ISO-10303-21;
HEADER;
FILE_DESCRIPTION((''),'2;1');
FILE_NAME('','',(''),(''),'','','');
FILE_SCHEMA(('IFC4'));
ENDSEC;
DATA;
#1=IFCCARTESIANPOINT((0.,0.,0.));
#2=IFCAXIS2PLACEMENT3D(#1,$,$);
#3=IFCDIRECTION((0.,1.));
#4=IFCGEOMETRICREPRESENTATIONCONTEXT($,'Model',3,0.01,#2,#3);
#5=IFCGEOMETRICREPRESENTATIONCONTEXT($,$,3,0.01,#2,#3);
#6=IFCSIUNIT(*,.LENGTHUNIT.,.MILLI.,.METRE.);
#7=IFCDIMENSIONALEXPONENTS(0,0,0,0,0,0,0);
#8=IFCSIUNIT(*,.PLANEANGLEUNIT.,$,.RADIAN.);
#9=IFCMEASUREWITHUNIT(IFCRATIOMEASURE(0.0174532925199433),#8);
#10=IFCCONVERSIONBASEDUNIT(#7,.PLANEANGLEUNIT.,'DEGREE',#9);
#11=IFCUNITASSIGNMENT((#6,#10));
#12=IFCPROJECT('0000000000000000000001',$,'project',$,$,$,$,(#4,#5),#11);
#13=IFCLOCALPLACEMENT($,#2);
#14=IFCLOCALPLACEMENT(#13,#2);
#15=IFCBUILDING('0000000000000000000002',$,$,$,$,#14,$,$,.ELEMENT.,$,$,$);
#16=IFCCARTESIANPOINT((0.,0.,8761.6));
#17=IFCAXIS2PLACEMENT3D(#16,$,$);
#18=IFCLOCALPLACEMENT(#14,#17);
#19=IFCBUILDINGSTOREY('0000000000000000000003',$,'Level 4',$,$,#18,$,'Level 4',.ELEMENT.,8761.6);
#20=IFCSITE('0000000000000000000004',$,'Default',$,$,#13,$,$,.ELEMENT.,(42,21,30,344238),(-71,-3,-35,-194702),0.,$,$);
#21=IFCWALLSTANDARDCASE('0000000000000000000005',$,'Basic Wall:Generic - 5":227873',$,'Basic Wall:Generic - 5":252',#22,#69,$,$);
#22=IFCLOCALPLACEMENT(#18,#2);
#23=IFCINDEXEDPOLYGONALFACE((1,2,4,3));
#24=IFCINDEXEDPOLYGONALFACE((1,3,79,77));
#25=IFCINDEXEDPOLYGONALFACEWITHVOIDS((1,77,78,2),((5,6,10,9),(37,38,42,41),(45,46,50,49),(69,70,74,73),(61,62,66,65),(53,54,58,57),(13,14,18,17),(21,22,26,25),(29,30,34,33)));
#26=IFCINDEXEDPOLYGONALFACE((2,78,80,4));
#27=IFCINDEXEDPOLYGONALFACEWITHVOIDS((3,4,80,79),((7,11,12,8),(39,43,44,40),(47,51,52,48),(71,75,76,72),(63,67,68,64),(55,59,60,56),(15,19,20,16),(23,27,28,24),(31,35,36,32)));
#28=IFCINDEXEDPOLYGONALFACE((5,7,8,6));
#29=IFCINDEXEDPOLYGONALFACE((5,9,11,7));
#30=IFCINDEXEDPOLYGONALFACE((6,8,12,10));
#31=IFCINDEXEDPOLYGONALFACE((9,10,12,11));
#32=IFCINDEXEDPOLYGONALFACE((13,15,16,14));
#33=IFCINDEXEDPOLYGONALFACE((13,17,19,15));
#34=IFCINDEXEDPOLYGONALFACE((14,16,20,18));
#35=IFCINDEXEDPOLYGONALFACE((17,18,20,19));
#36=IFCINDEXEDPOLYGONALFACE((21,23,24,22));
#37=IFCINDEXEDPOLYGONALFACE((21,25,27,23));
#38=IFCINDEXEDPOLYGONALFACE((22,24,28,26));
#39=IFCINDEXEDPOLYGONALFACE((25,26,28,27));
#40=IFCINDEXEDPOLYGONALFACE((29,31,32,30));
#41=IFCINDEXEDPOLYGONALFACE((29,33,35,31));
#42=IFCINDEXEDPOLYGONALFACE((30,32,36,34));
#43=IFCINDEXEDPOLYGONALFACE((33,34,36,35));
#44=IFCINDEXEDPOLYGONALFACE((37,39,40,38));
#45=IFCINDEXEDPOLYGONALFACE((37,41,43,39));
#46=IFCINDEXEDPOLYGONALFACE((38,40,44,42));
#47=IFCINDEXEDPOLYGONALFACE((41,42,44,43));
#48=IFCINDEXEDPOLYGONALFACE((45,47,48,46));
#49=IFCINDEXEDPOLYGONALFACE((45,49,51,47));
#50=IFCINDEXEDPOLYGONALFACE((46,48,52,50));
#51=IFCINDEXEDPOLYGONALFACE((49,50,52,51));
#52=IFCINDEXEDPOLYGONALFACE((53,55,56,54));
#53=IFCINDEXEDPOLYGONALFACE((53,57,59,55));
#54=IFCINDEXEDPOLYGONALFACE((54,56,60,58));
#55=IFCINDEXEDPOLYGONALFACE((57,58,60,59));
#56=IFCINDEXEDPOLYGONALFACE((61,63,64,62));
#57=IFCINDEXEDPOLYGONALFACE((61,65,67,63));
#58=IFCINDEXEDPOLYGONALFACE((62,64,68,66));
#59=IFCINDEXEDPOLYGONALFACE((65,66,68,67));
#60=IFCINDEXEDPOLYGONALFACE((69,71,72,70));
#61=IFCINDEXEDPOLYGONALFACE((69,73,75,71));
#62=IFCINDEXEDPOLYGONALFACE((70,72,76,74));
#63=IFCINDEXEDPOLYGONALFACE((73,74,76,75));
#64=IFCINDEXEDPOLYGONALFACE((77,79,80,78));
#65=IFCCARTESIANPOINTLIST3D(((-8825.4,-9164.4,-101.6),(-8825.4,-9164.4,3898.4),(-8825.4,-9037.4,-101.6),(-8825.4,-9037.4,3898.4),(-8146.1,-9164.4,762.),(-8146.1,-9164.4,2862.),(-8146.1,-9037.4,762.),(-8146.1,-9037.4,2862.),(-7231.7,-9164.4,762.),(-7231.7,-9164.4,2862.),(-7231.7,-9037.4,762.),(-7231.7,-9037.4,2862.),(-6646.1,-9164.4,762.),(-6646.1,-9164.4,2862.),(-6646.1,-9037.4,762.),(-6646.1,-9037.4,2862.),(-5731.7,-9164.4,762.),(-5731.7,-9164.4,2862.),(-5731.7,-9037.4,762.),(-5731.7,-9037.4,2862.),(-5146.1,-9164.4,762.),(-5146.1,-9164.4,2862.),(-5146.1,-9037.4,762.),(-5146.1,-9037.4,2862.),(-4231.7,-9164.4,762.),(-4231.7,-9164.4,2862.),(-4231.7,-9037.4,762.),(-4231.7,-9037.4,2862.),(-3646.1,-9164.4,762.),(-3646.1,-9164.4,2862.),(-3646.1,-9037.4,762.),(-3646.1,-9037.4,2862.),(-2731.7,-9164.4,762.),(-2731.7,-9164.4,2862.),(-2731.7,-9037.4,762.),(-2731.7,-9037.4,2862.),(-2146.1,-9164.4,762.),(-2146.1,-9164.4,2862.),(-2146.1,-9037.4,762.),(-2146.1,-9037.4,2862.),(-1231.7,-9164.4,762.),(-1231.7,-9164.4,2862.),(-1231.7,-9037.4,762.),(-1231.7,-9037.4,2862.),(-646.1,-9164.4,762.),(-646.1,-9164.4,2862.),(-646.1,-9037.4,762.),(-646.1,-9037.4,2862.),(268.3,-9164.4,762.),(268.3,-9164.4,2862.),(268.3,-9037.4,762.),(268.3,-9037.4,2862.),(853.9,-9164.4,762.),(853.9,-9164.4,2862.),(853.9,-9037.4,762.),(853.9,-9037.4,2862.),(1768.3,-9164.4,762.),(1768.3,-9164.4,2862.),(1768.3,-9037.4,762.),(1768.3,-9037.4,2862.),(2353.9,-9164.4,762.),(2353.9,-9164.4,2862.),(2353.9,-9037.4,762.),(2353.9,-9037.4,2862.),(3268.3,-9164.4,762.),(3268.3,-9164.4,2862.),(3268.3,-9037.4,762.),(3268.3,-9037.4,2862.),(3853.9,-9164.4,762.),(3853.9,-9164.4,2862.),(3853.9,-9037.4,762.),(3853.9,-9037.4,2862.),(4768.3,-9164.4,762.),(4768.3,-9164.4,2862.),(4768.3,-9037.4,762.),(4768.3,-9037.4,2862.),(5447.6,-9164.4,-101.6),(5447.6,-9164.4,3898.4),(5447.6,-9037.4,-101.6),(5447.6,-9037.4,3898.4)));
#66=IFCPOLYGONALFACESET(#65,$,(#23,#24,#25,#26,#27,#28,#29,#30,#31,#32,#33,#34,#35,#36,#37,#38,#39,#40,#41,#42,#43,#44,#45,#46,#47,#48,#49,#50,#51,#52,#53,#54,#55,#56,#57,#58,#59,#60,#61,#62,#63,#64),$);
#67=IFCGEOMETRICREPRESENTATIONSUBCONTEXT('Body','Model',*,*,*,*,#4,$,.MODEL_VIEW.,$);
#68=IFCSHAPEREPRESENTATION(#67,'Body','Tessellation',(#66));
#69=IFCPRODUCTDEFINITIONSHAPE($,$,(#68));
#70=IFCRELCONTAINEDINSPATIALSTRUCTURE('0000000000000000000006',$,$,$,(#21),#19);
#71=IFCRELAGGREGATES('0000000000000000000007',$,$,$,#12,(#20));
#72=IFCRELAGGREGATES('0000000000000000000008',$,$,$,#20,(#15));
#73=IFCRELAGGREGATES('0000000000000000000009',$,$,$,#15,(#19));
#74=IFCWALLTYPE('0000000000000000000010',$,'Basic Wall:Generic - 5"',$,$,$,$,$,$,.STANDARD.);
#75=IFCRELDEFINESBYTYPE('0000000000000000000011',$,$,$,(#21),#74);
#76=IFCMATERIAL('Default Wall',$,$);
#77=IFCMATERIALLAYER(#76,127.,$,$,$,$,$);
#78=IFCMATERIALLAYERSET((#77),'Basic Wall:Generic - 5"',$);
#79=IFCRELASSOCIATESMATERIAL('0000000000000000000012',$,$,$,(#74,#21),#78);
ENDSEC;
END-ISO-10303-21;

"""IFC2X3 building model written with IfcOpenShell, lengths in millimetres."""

from ifc_helpers import new_model, entity, si_unit, converted_unit, direction, frame, frame_2d, origin, place, context, subcontext, project, spatial, polyline, rectangle, extrude, clip, bounded_halfspace, material, layer, layer_set, layer_usage, type_object, element, save


model = new_model("IFC2X3")

# Units and contexts
model_context = context("Model", 3, precision=0.01, world=origin(), true_north=direction((0.0, 1.0)))
context_of_model = context(None, 3, precision=0.01, world=origin(), true_north=direction((0.0, 1.0)))
body_context = subcontext(model_context, "Body", "Model", "MODEL_VIEW")
ifc_project = project(units=[si_unit("LENGTHUNIT", "METRE", prefix="MILLI"), converted_unit("PLANEANGLEUNIT", "DEGREE", entity("IfcRatioMeasure", 0.0174532925199433), si_unit("PLANEANGLEUNIT", "RADIAN"), dimensions=[0, 0, 0, 0, 0, 0, 0])], contexts=[model_context, context_of_model])

# Site, building, storey
site_placement = place(None, origin())
site = spatial("IfcSite", under=ifc_project, at=site_placement, Name="Default", CompositionType="ELEMENT", RefLatitude=(42, 21, 30, 344238), RefLongitude=(-71, -3, -35, -194702), RefElevation=0.0)
building_placement = place(site_placement, origin())
building = spatial("IfcBuilding", under=site, at=building_placement, CompositionType="ELEMENT")
storey_placement = place(building_placement, frame((0.0, 0.0, 8761.6)))
storey = spatial("IfcBuildingStorey", under=building, at=storey_placement, Name="Level 4", LongName="Level 4", CompositionType="ELEMENT", Elevation=8761.6)

# Wall, openings
ifc_material = material(Name="Default Wall")
ifc_layer = layer(ifc_material, 127.0)
ifc_layer_set = layer_set([ifc_layer], Name="Basic Wall:Generic - 5\"")
wall_type = type_object("IfcWallType", Name="Basic Wall:Generic - 5\"", PredefinedType="STANDARD", material=ifc_layer_set)
ifc_layer_usage_1 = layer_usage(ifc_layer_set, "AXIS2", "NEGATIVE", 63.5)
wall_1_placement = place(storey_placement, frame((5447.6, -9100.9, -101.6), z_axis=(0.0, 0.0, 1.0), x_axis=(-1.0, 0.0, 0.0)))
wall_1 = element("IfcWallStandardCase", 1, at=wall_1_placement, inside=storey, type_object=wall_type, material=ifc_layer_usage_1, Name="Basic Wall:Generic - 5\":227873", ObjectType="Basic Wall:Generic - 5\":252", context=body_context, shape_type="Clipping", body=[
    clip(extrude(rectangle(XDim=14273.0, YDim=127.0, at=frame_2d((7136.5, 0.0), x_axis=(-1.0, 0.0))), origin(), (0.0, 0.0, 1.0), 4000.0), bounded_halfspace(frame((0.0, -63.5, 4000.0), z_axis=(0.0, 0.0, -1.0), x_axis=(0.0, 1.0, 0.0)), True, frame((0.0, -63.5, 4000.0)), polyline([(0.0, 0.0), (14273.0, 0.0), (14273.0, 127.0), (0.0, 127.0), (0.0, 0.0)]))),
])
opening_1_placement = place(wall_1_placement, frame((13593.7, 63.5, 863.6)))
element("IfcOpeningElement", 2, at=opening_1_placement, cuts=wall_1, ObjectType="Opening", context=body_context, shape_type="SweptSolid", body=[
    extrude(rectangle(XDim=2100.0, YDim=914.4, at=frame_2d((1050.0, 457.2), x_axis=(-1.0, 0.0))), frame((0.0, 0.0, 0.0), z_axis=(0.0, -1.0, 0.0), x_axis=(0.0, 0.0, 1.0)), (0.0, 0.0, 1.0), 127.0),
])
opening_2_placement = place(wall_1_placement, frame((10593.7, 63.5, 863.6)))
element("IfcOpeningElement", 3, at=opening_2_placement, cuts=wall_1, ObjectType="Opening", context=body_context, shape_type="SweptSolid", body=[
    extrude(rectangle(XDim=2100.0, YDim=914.4, at=frame_2d((1050.0, 457.2), x_axis=(-1.0, 0.0))), frame((0.0, 0.0, 0.0), z_axis=(0.0, -1.0, 0.0), x_axis=(0.0, 0.0, 1.0)), (0.0, 0.0, 1.0), 127.0),
])
opening_3_placement = place(wall_1_placement, frame((7593.7, 63.5, 863.6)))
element("IfcOpeningElement", 4, at=opening_3_placement, cuts=wall_1, ObjectType="Opening", context=body_context, shape_type="SweptSolid", body=[
    extrude(rectangle(XDim=2100.0, YDim=914.4, at=frame_2d((1050.0, 457.2), x_axis=(-1.0, 0.0))), frame((0.0, 0.0, 0.0), z_axis=(0.0, -1.0, 0.0), x_axis=(0.0, 0.0, 1.0)), (0.0, 0.0, 1.0), 127.0),
])
opening_4_placement = place(wall_1_placement, frame((4593.7, 63.5, 863.6)))
element("IfcOpeningElement", 5, at=opening_4_placement, cuts=wall_1, ObjectType="Opening", context=body_context, shape_type="SweptSolid", body=[
    extrude(rectangle(XDim=2100.0, YDim=914.4, at=frame_2d((1050.0, 457.2), x_axis=(-1.0, 0.0))), frame((0.0, 0.0, 0.0), z_axis=(0.0, -1.0, 0.0), x_axis=(0.0, 0.0, 1.0)), (0.0, 0.0, 1.0), 127.0),
])
opening_5_placement = place(wall_1_placement, frame((1593.7, 63.5, 863.6)))
element("IfcOpeningElement", 6, at=opening_5_placement, cuts=wall_1, ObjectType="Opening", context=body_context, shape_type="SweptSolid", body=[
    extrude(rectangle(XDim=2100.0, YDim=914.4, at=frame_2d((1050.0, 457.2), x_axis=(-1.0, 0.0))), frame((0.0, 0.0, 0.0), z_axis=(0.0, -1.0, 0.0), x_axis=(0.0, 0.0, 1.0)), (0.0, 0.0, 1.0), 127.0),
])
opening_6_placement = place(wall_1_placement, frame((12093.7, 63.5, 863.6)))
element("IfcOpeningElement", 7, at=opening_6_placement, cuts=wall_1, ObjectType="Opening", context=body_context, shape_type="SweptSolid", body=[
    extrude(rectangle(XDim=2100.0, YDim=914.4, at=frame_2d((1050.0, 457.2), x_axis=(-1.0, 0.0))), frame((0.0, 0.0, 0.0), z_axis=(0.0, -1.0, 0.0), x_axis=(0.0, 0.0, 1.0)), (0.0, 0.0, 1.0), 127.0),
])
opening_7_placement = place(wall_1_placement, frame((9093.7, 63.5, 863.6)))
element("IfcOpeningElement", 8, at=opening_7_placement, cuts=wall_1, ObjectType="Opening", context=body_context, shape_type="SweptSolid", body=[
    extrude(rectangle(XDim=2100.0, YDim=914.4, at=frame_2d((1050.0, 457.2), x_axis=(-1.0, 0.0))), frame((0.0, 0.0, 0.0), z_axis=(0.0, -1.0, 0.0), x_axis=(0.0, 0.0, 1.0)), (0.0, 0.0, 1.0), 127.0),
])
opening_8_placement = place(wall_1_placement, frame((6093.7, 63.5, 863.6)))
element("IfcOpeningElement", 9, at=opening_8_placement, cuts=wall_1, ObjectType="Opening", context=body_context, shape_type="SweptSolid", body=[
    extrude(rectangle(XDim=2100.0, YDim=914.4, at=frame_2d((1050.0, 457.2), x_axis=(-1.0, 0.0))), frame((0.0, 0.0, 0.0), z_axis=(0.0, -1.0, 0.0), x_axis=(0.0, 0.0, 1.0)), (0.0, 0.0, 1.0), 127.0),
])
opening_9_placement = place(wall_1_placement, frame((3093.7, 63.5, 863.6)))
element("IfcOpeningElement", 10, at=opening_9_placement, cuts=wall_1, ObjectType="Opening", context=body_context, shape_type="SweptSolid", body=[
    extrude(rectangle(XDim=2100.0, YDim=914.4, at=frame_2d((1050.0, 457.2), x_axis=(-1.0, 0.0))), frame((0.0, 0.0, 0.0), z_axis=(0.0, -1.0, 0.0), x_axis=(0.0, 0.0, 1.0)), (0.0, 0.0, 1.0), 127.0),
])

save(model, "model.ifc")
